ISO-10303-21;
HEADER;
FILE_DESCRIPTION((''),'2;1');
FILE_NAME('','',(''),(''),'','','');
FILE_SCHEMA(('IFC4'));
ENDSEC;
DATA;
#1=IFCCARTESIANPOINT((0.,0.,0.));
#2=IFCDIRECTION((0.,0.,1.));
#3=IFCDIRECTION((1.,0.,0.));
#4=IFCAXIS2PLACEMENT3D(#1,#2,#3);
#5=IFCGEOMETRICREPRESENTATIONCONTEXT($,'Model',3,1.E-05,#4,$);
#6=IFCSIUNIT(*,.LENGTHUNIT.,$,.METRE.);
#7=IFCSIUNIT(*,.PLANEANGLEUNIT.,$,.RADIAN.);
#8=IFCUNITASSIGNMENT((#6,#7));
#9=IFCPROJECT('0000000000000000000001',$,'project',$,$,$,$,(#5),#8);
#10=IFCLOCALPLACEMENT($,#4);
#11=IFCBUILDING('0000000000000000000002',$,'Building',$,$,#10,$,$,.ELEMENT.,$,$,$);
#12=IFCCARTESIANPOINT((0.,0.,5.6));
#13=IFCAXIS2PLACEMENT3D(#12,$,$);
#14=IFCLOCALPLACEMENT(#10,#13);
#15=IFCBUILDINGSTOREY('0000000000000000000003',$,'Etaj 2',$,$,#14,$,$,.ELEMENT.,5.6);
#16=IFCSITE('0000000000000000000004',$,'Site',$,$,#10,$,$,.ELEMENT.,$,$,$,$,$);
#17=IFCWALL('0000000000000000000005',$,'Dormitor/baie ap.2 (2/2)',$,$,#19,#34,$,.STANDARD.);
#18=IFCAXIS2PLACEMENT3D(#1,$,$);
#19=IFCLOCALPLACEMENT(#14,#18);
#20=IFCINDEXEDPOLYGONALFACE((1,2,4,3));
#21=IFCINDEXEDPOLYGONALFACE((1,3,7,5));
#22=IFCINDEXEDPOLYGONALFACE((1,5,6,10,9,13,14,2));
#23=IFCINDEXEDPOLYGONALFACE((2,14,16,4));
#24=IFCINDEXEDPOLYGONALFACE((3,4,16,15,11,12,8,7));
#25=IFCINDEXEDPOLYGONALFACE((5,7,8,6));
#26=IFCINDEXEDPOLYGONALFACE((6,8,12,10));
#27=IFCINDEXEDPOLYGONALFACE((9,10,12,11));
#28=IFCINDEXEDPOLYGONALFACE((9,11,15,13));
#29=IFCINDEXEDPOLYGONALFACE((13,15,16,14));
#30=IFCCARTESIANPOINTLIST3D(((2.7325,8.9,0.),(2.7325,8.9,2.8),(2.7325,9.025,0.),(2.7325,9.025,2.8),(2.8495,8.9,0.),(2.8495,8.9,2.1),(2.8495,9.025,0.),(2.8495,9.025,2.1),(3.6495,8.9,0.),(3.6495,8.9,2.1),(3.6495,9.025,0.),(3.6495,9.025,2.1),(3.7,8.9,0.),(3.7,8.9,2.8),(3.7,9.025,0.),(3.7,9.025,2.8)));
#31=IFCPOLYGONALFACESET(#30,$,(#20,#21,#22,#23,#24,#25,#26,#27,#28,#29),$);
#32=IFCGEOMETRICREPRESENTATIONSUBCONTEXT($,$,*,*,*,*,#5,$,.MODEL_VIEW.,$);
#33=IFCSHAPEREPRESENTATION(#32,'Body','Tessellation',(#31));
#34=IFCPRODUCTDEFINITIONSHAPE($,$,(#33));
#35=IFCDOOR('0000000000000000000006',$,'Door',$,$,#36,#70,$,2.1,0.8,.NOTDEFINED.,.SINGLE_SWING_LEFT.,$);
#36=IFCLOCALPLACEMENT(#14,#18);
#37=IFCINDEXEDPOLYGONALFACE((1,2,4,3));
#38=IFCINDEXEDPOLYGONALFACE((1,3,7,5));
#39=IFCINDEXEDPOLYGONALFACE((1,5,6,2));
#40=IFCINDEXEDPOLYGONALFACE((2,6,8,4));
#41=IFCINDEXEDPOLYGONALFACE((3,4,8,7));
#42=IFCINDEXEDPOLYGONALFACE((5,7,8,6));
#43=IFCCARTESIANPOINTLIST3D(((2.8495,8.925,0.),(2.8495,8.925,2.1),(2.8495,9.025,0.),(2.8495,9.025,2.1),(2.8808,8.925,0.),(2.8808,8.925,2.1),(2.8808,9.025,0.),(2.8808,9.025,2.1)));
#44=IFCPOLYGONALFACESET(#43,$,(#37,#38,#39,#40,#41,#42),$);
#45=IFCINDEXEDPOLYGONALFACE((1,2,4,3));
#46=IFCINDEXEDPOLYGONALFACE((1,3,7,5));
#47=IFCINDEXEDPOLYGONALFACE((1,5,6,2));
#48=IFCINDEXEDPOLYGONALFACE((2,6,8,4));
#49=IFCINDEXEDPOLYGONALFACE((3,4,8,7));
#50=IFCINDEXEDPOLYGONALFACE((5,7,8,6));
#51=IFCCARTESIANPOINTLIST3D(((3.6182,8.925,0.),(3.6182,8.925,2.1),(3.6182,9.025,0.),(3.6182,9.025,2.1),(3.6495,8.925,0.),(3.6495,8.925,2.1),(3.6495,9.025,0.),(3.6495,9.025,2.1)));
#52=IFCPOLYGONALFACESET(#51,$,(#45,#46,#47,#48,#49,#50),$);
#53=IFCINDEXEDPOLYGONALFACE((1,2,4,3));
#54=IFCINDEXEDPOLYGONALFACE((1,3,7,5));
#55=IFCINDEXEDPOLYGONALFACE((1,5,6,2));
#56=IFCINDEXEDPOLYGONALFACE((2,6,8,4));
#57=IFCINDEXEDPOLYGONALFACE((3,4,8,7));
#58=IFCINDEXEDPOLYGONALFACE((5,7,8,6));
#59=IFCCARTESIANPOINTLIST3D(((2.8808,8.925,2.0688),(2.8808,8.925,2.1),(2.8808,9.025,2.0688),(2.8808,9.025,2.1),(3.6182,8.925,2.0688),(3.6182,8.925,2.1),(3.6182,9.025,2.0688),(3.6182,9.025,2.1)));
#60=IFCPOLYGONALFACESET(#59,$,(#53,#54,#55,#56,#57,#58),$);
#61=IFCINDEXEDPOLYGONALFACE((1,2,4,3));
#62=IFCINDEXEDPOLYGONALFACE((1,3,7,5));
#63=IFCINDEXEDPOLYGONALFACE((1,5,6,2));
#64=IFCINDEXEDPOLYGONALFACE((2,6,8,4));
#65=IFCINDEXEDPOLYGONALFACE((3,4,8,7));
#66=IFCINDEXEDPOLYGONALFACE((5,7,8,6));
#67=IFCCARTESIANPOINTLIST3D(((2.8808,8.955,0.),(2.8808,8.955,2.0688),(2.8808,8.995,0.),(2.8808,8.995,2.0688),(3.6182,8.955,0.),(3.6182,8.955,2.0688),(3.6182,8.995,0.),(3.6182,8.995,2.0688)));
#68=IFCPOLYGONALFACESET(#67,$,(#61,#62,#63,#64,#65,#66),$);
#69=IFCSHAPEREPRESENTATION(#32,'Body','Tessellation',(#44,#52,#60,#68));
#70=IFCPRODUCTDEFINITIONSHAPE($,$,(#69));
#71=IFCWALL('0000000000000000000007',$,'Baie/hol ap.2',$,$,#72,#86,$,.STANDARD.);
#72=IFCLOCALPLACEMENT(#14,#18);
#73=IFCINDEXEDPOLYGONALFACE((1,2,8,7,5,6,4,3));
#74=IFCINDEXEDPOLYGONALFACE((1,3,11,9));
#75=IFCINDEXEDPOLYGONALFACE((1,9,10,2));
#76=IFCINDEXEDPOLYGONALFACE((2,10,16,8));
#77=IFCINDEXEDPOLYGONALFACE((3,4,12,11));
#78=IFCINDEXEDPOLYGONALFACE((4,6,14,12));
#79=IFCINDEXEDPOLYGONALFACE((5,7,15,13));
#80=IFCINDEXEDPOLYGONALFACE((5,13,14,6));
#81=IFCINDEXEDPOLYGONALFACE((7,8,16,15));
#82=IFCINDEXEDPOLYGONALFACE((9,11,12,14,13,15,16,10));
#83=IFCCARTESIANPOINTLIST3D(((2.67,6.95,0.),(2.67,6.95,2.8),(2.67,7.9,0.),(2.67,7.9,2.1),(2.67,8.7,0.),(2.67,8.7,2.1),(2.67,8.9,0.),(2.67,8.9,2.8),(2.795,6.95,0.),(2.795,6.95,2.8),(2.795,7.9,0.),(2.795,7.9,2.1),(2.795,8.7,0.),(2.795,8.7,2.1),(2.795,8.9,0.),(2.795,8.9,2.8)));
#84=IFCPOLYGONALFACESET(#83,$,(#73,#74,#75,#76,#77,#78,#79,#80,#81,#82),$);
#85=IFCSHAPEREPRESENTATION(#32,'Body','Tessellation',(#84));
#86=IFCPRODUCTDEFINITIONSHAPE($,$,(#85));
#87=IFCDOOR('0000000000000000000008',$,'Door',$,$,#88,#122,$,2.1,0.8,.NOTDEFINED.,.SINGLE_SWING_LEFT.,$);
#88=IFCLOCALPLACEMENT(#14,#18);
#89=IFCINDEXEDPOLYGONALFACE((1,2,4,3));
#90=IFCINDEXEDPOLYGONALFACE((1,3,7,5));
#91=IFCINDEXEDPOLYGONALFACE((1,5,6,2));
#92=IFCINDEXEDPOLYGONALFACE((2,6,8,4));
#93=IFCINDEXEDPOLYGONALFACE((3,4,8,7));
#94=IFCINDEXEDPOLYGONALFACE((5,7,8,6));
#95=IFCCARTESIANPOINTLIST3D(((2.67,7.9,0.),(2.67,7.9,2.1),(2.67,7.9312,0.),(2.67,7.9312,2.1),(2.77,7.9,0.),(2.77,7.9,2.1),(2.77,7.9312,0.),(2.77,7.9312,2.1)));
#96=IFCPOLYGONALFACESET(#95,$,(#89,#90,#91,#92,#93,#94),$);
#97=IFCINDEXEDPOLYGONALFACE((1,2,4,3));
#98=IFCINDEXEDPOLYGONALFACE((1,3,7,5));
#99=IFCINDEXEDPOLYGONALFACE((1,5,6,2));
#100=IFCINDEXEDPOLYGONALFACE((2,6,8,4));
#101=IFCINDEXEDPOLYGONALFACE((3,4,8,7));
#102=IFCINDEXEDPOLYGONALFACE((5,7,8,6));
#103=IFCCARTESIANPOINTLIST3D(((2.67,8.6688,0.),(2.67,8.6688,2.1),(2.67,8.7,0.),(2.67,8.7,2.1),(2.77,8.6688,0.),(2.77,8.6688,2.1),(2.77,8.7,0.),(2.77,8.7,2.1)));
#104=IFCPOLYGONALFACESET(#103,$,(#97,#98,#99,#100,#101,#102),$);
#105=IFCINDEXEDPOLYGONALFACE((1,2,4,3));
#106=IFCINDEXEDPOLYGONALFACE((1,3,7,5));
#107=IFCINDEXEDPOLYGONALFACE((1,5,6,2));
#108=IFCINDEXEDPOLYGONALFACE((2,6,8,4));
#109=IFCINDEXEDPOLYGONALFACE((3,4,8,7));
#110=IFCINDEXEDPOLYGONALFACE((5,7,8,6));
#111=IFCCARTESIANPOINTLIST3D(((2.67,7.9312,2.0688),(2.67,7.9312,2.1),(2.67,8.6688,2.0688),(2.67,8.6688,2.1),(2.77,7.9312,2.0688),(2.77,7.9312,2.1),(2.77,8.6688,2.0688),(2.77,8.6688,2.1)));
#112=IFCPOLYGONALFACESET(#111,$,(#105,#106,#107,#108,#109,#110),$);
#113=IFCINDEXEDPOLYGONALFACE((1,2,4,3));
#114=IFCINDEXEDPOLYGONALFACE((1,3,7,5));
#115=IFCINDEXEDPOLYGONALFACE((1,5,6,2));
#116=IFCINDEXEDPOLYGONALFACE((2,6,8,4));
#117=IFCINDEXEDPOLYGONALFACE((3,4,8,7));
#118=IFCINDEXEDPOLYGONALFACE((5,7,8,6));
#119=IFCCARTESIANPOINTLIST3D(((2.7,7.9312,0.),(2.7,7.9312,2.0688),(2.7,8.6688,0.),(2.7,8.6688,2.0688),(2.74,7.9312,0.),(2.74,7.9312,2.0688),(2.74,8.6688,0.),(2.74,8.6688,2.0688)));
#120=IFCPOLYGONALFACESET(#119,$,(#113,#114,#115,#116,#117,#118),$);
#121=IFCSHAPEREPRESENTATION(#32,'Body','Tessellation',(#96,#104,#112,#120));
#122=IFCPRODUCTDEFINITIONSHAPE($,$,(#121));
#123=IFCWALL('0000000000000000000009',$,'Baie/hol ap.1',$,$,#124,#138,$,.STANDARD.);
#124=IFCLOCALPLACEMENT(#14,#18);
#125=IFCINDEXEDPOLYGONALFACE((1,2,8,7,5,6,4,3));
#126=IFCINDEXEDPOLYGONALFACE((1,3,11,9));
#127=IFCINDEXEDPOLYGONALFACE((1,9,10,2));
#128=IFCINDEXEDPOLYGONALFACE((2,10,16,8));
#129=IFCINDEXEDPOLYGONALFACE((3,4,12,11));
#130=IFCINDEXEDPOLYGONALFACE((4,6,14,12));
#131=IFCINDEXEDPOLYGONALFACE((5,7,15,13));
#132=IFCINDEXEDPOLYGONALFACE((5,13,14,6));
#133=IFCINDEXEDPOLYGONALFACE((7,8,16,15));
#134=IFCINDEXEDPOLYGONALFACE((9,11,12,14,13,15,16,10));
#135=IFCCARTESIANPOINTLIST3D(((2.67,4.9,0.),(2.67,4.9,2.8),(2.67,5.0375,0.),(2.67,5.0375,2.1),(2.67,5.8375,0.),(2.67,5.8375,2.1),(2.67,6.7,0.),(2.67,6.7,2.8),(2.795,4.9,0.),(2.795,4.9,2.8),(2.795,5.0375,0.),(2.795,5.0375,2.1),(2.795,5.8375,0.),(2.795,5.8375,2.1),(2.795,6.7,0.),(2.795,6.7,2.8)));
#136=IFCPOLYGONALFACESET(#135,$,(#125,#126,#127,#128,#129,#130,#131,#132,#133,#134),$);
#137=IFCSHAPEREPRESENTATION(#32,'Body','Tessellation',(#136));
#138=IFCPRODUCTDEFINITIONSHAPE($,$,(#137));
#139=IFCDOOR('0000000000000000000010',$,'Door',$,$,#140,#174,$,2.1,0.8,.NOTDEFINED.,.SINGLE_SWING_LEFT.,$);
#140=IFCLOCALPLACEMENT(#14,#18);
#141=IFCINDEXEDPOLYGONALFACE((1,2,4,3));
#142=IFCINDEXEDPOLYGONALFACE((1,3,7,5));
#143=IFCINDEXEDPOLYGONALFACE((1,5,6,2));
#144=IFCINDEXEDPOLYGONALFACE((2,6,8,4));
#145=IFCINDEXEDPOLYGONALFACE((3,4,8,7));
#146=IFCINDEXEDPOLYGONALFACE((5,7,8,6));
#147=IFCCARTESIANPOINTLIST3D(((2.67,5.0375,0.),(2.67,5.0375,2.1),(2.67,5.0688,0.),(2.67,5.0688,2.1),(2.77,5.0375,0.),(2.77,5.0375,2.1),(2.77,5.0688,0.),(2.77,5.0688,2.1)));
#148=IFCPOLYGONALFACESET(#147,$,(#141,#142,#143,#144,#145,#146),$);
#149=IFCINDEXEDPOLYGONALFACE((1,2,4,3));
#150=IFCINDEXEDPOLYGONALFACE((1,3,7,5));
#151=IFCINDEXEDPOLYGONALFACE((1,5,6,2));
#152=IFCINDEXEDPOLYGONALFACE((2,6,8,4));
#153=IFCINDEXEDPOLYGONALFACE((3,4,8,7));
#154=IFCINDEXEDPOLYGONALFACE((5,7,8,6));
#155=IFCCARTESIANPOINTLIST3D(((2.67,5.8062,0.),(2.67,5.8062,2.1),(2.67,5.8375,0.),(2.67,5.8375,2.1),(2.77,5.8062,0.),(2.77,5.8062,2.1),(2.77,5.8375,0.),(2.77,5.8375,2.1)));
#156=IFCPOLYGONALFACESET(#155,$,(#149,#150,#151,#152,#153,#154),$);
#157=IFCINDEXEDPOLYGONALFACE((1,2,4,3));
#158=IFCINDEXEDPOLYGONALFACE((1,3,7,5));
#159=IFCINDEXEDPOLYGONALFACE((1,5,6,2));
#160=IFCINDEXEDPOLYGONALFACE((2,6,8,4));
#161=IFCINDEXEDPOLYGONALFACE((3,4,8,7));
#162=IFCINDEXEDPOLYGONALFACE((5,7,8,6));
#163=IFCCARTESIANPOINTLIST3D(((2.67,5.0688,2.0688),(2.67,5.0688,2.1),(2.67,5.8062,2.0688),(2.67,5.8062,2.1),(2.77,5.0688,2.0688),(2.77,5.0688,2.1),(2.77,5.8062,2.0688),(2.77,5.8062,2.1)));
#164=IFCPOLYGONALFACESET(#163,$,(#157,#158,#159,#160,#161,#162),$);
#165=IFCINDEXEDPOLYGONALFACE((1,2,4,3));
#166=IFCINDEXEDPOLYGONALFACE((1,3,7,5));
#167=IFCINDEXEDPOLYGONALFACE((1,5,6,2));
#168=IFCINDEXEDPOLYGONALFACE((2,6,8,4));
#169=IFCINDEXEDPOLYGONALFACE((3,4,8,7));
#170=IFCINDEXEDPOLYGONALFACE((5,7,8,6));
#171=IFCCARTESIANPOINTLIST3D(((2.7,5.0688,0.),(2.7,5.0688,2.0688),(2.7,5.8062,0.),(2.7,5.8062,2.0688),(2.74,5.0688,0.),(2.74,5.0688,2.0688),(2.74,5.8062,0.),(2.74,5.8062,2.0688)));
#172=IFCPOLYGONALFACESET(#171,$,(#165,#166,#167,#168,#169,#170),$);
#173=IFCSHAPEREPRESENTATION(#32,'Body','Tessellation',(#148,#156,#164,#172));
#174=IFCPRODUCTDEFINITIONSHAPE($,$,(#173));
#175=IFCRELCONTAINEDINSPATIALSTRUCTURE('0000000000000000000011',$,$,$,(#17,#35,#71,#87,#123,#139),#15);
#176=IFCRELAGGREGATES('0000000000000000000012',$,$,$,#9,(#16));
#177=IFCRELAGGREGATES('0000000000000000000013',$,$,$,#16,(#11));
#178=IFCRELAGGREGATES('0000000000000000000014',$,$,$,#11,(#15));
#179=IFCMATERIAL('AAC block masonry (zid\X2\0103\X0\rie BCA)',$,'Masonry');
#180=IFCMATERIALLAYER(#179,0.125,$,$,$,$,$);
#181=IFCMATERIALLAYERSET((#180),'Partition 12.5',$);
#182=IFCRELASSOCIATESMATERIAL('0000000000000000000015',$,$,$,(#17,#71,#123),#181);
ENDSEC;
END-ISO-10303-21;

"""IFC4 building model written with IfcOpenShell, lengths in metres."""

from ifc_helpers import new_model, si_unit, frame, frame_2d, origin, origin_with_axes, origin_2d, place, context, subcontext, project, spatial, rectangle, extrude, material, layer, layer_set, layer_usage, element, fill, save


model = new_model("IFC4")

# Units and contexts
model_context = context("Model", 3, precision=1e-05, world=origin_with_axes())
sub_context = subcontext(model_context, None, None, "MODEL_VIEW")
ifc_project = project(units=[si_unit("LENGTHUNIT", "METRE"), si_unit("PLANEANGLEUNIT", "RADIAN")], contexts=[model_context])

# Site, building, storey
placement = place(None, origin_with_axes())
site = spatial("IfcSite", under=ifc_project, at=placement, Name="Site", CompositionType="ELEMENT")
building = spatial("IfcBuilding", under=site, at=placement, Name="Building", CompositionType="ELEMENT")
storey_placement = place(placement, frame((0.0, 0.0, 5.6)))
storey = spatial("IfcBuildingStorey", under=building, at=storey_placement, Name="Etaj 2", CompositionType="ELEMENT", Elevation=5.6)

# Shared definitions
ifc_material_1 = material(Name="AAC block masonry (zidărie BCA)", Category="Masonry")
ifc_layer_1 = layer(ifc_material_1, 0.125)
ifc_layer_set_1 = layer_set([ifc_layer_1], Name="Partition 12.5")
ifc_layer_usage_1 = layer_usage(ifc_layer_set_1, "AXIS2", "POSITIVE", -0.0625)

# Walls, openings, doors
wall_1_placement = place(storey_placement, frame((2.7325, 8.9625, 0.0), x_axis=(1.0, 0.0, 0.0)))
wall_1 = element("IfcWall", 1, at=wall_1_placement, inside=storey, material=ifc_layer_usage_1, Name="Dormitor/baie ap.2 (2/2)", PredefinedType="STANDARD", context=sub_context, shape_type="SweptSolid", body=[
    extrude(rectangle(XDim=0.9675, YDim=0.125, at=frame_2d((0.4838, 0.0))), origin(), (0.0, 0.0, 1.0), 2.8),
])
opening_1_placement = place(wall_1_placement, frame((0.517, 0.1125, 0.0), z_axis=(0.0, -1.0, 0.0), x_axis=(1.0, 0.0, 0.0)))
opening_1 = element("IfcOpeningElement", 2, at=opening_1_placement, cuts=wall_1, PredefinedType="OPENING", context=sub_context, shape_type="SweptSolid", body=[
    extrude(rectangle(XDim=0.8, YDim=2.1, at=frame_2d((0.0, 1.05))), origin(), (0.0, 0.0, 1.0), 0.225),
])
door_1_placement = place(wall_1_placement, frame((0.517, 0.0625, 0.0), z_axis=(0.0, -1.0, 0.0), x_axis=(1.0, 0.0, 0.0)))
door_1 = element("IfcDoor", 3, at=door_1_placement, inside=storey, Name="Door", OperationType="SINGLE_SWING_LEFT", OverallHeight=2.1, OverallWidth=0.8, PredefinedType="NOTDEFINED", context=sub_context, shape_type="SweptSolid", body=[
    extrude(rectangle(XDim=0.0312, YDim=2.1, at=origin_2d()), frame((-0.3844, 1.05, 0.0)), (0.0, 0.0, 1.0), 0.1),
    extrude(rectangle(XDim=0.0312, YDim=2.1, at=origin_2d()), frame((0.3844, 1.05, 0.0)), (0.0, 0.0, 1.0), 0.1),
    extrude(rectangle(XDim=0.7375, YDim=0.0312, at=origin_2d()), frame((0.0, 2.0844, 0.0)), (0.0, 0.0, 1.0), 0.1),
    extrude(rectangle(XDim=0.7375, YDim=2.0688, at=origin_2d()), frame((0.0, 1.0344, 0.03)), (0.0, 0.0, 1.0), 0.04),
])
fill(opening_1, door_1)
wall_2_placement = place(storey_placement, frame((2.7325, 6.95, 0.0), x_axis=(0.0, 1.0, 0.0)))
wall_2 = element("IfcWall", 4, at=wall_2_placement, inside=storey, material=ifc_layer_usage_1, Name="Baie/hol ap.2", PredefinedType="STANDARD", context=sub_context, shape_type="SweptSolid", body=[
    extrude(rectangle(XDim=1.95, YDim=0.125, at=frame_2d((0.975, 0.0))), origin(), (0.0, 0.0, 1.0), 2.8),
])
opening_2_placement = place(wall_2_placement, frame((1.35, 0.1125, 0.0), z_axis=(0.0, -1.0, 0.0), x_axis=(1.0, 0.0, 0.0)))
opening_2 = element("IfcOpeningElement", 5, at=opening_2_placement, cuts=wall_2, PredefinedType="OPENING", context=sub_context, shape_type="SweptSolid", body=[
    extrude(rectangle(XDim=0.8, YDim=2.1, at=frame_2d((0.0, 1.05))), origin(), (0.0, 0.0, 1.0), 0.225),
])
door_2_placement = place(wall_2_placement, frame((1.35, 0.0625, 0.0), z_axis=(0.0, -1.0, 0.0), x_axis=(1.0, 0.0, 0.0)))
door_2 = element("IfcDoor", 6, at=door_2_placement, inside=storey, Name="Door", OperationType="SINGLE_SWING_LEFT", OverallHeight=2.1, OverallWidth=0.8, PredefinedType="NOTDEFINED", context=sub_context, shape_type="SweptSolid", body=[
    extrude(rectangle(XDim=0.0312, YDim=2.1, at=origin_2d()), frame((-0.3844, 1.05, 0.0)), (0.0, 0.0, 1.0), 0.1),
    extrude(rectangle(XDim=0.0312, YDim=2.1, at=origin_2d()), frame((0.3844, 1.05, 0.0)), (0.0, 0.0, 1.0), 0.1),
    extrude(rectangle(XDim=0.7375, YDim=0.0312, at=origin_2d()), frame((0.0, 2.0844, 0.0)), (0.0, 0.0, 1.0), 0.1),
    extrude(rectangle(XDim=0.7375, YDim=2.0688, at=origin_2d()), frame((0.0, 1.0344, 0.03)), (0.0, 0.0, 1.0), 0.04),
])
fill(opening_2, door_2)
wall_3_placement = place(storey_placement, frame((2.7325, 4.9, 0.0), x_axis=(0.0, 1.0, 0.0)))
wall_3 = element("IfcWall", 7, at=wall_3_placement, inside=storey, material=ifc_layer_usage_1, Name="Baie/hol ap.1", PredefinedType="STANDARD", context=sub_context, shape_type="SweptSolid", body=[
    extrude(rectangle(XDim=1.8, YDim=0.125, at=frame_2d((0.9, 0.0))), origin(), (0.0, 0.0, 1.0), 2.8),
])
opening_3_placement = place(wall_3_placement, frame((0.5375, 0.1125, 0.0), z_axis=(0.0, -1.0, 0.0), x_axis=(1.0, 0.0, 0.0)))
opening_3 = element("IfcOpeningElement", 8, at=opening_3_placement, cuts=wall_3, PredefinedType="OPENING", context=sub_context, shape_type="SweptSolid", body=[
    extrude(rectangle(XDim=0.8, YDim=2.1, at=frame_2d((0.0, 1.05))), origin(), (0.0, 0.0, 1.0), 0.225),
])
door_3_placement = place(wall_3_placement, frame((0.5375, 0.0625, 0.0), z_axis=(0.0, -1.0, 0.0), x_axis=(1.0, 0.0, 0.0)))
door_3 = element("IfcDoor", 9, at=door_3_placement, inside=storey, Name="Door", OperationType="SINGLE_SWING_LEFT", OverallHeight=2.1, OverallWidth=0.8, PredefinedType="NOTDEFINED", context=sub_context, shape_type="SweptSolid", body=[
    extrude(rectangle(XDim=0.0312, YDim=2.1, at=origin_2d()), frame((-0.3844, 1.05, 0.0)), (0.0, 0.0, 1.0), 0.1),
    extrude(rectangle(XDim=0.0312, YDim=2.1, at=origin_2d()), frame((0.3844, 1.05, 0.0)), (0.0, 0.0, 1.0), 0.1),
    extrude(rectangle(XDim=0.7375, YDim=0.0312, at=origin_2d()), frame((0.0, 2.0844, 0.0)), (0.0, 0.0, 1.0), 0.1),
    extrude(rectangle(XDim=0.7375, YDim=2.0688, at=origin_2d()), frame((0.0, 1.0344, 0.03)), (0.0, 0.0, 1.0), 0.04),
])
fill(opening_3, door_3)

save(model, "model.ifc")
